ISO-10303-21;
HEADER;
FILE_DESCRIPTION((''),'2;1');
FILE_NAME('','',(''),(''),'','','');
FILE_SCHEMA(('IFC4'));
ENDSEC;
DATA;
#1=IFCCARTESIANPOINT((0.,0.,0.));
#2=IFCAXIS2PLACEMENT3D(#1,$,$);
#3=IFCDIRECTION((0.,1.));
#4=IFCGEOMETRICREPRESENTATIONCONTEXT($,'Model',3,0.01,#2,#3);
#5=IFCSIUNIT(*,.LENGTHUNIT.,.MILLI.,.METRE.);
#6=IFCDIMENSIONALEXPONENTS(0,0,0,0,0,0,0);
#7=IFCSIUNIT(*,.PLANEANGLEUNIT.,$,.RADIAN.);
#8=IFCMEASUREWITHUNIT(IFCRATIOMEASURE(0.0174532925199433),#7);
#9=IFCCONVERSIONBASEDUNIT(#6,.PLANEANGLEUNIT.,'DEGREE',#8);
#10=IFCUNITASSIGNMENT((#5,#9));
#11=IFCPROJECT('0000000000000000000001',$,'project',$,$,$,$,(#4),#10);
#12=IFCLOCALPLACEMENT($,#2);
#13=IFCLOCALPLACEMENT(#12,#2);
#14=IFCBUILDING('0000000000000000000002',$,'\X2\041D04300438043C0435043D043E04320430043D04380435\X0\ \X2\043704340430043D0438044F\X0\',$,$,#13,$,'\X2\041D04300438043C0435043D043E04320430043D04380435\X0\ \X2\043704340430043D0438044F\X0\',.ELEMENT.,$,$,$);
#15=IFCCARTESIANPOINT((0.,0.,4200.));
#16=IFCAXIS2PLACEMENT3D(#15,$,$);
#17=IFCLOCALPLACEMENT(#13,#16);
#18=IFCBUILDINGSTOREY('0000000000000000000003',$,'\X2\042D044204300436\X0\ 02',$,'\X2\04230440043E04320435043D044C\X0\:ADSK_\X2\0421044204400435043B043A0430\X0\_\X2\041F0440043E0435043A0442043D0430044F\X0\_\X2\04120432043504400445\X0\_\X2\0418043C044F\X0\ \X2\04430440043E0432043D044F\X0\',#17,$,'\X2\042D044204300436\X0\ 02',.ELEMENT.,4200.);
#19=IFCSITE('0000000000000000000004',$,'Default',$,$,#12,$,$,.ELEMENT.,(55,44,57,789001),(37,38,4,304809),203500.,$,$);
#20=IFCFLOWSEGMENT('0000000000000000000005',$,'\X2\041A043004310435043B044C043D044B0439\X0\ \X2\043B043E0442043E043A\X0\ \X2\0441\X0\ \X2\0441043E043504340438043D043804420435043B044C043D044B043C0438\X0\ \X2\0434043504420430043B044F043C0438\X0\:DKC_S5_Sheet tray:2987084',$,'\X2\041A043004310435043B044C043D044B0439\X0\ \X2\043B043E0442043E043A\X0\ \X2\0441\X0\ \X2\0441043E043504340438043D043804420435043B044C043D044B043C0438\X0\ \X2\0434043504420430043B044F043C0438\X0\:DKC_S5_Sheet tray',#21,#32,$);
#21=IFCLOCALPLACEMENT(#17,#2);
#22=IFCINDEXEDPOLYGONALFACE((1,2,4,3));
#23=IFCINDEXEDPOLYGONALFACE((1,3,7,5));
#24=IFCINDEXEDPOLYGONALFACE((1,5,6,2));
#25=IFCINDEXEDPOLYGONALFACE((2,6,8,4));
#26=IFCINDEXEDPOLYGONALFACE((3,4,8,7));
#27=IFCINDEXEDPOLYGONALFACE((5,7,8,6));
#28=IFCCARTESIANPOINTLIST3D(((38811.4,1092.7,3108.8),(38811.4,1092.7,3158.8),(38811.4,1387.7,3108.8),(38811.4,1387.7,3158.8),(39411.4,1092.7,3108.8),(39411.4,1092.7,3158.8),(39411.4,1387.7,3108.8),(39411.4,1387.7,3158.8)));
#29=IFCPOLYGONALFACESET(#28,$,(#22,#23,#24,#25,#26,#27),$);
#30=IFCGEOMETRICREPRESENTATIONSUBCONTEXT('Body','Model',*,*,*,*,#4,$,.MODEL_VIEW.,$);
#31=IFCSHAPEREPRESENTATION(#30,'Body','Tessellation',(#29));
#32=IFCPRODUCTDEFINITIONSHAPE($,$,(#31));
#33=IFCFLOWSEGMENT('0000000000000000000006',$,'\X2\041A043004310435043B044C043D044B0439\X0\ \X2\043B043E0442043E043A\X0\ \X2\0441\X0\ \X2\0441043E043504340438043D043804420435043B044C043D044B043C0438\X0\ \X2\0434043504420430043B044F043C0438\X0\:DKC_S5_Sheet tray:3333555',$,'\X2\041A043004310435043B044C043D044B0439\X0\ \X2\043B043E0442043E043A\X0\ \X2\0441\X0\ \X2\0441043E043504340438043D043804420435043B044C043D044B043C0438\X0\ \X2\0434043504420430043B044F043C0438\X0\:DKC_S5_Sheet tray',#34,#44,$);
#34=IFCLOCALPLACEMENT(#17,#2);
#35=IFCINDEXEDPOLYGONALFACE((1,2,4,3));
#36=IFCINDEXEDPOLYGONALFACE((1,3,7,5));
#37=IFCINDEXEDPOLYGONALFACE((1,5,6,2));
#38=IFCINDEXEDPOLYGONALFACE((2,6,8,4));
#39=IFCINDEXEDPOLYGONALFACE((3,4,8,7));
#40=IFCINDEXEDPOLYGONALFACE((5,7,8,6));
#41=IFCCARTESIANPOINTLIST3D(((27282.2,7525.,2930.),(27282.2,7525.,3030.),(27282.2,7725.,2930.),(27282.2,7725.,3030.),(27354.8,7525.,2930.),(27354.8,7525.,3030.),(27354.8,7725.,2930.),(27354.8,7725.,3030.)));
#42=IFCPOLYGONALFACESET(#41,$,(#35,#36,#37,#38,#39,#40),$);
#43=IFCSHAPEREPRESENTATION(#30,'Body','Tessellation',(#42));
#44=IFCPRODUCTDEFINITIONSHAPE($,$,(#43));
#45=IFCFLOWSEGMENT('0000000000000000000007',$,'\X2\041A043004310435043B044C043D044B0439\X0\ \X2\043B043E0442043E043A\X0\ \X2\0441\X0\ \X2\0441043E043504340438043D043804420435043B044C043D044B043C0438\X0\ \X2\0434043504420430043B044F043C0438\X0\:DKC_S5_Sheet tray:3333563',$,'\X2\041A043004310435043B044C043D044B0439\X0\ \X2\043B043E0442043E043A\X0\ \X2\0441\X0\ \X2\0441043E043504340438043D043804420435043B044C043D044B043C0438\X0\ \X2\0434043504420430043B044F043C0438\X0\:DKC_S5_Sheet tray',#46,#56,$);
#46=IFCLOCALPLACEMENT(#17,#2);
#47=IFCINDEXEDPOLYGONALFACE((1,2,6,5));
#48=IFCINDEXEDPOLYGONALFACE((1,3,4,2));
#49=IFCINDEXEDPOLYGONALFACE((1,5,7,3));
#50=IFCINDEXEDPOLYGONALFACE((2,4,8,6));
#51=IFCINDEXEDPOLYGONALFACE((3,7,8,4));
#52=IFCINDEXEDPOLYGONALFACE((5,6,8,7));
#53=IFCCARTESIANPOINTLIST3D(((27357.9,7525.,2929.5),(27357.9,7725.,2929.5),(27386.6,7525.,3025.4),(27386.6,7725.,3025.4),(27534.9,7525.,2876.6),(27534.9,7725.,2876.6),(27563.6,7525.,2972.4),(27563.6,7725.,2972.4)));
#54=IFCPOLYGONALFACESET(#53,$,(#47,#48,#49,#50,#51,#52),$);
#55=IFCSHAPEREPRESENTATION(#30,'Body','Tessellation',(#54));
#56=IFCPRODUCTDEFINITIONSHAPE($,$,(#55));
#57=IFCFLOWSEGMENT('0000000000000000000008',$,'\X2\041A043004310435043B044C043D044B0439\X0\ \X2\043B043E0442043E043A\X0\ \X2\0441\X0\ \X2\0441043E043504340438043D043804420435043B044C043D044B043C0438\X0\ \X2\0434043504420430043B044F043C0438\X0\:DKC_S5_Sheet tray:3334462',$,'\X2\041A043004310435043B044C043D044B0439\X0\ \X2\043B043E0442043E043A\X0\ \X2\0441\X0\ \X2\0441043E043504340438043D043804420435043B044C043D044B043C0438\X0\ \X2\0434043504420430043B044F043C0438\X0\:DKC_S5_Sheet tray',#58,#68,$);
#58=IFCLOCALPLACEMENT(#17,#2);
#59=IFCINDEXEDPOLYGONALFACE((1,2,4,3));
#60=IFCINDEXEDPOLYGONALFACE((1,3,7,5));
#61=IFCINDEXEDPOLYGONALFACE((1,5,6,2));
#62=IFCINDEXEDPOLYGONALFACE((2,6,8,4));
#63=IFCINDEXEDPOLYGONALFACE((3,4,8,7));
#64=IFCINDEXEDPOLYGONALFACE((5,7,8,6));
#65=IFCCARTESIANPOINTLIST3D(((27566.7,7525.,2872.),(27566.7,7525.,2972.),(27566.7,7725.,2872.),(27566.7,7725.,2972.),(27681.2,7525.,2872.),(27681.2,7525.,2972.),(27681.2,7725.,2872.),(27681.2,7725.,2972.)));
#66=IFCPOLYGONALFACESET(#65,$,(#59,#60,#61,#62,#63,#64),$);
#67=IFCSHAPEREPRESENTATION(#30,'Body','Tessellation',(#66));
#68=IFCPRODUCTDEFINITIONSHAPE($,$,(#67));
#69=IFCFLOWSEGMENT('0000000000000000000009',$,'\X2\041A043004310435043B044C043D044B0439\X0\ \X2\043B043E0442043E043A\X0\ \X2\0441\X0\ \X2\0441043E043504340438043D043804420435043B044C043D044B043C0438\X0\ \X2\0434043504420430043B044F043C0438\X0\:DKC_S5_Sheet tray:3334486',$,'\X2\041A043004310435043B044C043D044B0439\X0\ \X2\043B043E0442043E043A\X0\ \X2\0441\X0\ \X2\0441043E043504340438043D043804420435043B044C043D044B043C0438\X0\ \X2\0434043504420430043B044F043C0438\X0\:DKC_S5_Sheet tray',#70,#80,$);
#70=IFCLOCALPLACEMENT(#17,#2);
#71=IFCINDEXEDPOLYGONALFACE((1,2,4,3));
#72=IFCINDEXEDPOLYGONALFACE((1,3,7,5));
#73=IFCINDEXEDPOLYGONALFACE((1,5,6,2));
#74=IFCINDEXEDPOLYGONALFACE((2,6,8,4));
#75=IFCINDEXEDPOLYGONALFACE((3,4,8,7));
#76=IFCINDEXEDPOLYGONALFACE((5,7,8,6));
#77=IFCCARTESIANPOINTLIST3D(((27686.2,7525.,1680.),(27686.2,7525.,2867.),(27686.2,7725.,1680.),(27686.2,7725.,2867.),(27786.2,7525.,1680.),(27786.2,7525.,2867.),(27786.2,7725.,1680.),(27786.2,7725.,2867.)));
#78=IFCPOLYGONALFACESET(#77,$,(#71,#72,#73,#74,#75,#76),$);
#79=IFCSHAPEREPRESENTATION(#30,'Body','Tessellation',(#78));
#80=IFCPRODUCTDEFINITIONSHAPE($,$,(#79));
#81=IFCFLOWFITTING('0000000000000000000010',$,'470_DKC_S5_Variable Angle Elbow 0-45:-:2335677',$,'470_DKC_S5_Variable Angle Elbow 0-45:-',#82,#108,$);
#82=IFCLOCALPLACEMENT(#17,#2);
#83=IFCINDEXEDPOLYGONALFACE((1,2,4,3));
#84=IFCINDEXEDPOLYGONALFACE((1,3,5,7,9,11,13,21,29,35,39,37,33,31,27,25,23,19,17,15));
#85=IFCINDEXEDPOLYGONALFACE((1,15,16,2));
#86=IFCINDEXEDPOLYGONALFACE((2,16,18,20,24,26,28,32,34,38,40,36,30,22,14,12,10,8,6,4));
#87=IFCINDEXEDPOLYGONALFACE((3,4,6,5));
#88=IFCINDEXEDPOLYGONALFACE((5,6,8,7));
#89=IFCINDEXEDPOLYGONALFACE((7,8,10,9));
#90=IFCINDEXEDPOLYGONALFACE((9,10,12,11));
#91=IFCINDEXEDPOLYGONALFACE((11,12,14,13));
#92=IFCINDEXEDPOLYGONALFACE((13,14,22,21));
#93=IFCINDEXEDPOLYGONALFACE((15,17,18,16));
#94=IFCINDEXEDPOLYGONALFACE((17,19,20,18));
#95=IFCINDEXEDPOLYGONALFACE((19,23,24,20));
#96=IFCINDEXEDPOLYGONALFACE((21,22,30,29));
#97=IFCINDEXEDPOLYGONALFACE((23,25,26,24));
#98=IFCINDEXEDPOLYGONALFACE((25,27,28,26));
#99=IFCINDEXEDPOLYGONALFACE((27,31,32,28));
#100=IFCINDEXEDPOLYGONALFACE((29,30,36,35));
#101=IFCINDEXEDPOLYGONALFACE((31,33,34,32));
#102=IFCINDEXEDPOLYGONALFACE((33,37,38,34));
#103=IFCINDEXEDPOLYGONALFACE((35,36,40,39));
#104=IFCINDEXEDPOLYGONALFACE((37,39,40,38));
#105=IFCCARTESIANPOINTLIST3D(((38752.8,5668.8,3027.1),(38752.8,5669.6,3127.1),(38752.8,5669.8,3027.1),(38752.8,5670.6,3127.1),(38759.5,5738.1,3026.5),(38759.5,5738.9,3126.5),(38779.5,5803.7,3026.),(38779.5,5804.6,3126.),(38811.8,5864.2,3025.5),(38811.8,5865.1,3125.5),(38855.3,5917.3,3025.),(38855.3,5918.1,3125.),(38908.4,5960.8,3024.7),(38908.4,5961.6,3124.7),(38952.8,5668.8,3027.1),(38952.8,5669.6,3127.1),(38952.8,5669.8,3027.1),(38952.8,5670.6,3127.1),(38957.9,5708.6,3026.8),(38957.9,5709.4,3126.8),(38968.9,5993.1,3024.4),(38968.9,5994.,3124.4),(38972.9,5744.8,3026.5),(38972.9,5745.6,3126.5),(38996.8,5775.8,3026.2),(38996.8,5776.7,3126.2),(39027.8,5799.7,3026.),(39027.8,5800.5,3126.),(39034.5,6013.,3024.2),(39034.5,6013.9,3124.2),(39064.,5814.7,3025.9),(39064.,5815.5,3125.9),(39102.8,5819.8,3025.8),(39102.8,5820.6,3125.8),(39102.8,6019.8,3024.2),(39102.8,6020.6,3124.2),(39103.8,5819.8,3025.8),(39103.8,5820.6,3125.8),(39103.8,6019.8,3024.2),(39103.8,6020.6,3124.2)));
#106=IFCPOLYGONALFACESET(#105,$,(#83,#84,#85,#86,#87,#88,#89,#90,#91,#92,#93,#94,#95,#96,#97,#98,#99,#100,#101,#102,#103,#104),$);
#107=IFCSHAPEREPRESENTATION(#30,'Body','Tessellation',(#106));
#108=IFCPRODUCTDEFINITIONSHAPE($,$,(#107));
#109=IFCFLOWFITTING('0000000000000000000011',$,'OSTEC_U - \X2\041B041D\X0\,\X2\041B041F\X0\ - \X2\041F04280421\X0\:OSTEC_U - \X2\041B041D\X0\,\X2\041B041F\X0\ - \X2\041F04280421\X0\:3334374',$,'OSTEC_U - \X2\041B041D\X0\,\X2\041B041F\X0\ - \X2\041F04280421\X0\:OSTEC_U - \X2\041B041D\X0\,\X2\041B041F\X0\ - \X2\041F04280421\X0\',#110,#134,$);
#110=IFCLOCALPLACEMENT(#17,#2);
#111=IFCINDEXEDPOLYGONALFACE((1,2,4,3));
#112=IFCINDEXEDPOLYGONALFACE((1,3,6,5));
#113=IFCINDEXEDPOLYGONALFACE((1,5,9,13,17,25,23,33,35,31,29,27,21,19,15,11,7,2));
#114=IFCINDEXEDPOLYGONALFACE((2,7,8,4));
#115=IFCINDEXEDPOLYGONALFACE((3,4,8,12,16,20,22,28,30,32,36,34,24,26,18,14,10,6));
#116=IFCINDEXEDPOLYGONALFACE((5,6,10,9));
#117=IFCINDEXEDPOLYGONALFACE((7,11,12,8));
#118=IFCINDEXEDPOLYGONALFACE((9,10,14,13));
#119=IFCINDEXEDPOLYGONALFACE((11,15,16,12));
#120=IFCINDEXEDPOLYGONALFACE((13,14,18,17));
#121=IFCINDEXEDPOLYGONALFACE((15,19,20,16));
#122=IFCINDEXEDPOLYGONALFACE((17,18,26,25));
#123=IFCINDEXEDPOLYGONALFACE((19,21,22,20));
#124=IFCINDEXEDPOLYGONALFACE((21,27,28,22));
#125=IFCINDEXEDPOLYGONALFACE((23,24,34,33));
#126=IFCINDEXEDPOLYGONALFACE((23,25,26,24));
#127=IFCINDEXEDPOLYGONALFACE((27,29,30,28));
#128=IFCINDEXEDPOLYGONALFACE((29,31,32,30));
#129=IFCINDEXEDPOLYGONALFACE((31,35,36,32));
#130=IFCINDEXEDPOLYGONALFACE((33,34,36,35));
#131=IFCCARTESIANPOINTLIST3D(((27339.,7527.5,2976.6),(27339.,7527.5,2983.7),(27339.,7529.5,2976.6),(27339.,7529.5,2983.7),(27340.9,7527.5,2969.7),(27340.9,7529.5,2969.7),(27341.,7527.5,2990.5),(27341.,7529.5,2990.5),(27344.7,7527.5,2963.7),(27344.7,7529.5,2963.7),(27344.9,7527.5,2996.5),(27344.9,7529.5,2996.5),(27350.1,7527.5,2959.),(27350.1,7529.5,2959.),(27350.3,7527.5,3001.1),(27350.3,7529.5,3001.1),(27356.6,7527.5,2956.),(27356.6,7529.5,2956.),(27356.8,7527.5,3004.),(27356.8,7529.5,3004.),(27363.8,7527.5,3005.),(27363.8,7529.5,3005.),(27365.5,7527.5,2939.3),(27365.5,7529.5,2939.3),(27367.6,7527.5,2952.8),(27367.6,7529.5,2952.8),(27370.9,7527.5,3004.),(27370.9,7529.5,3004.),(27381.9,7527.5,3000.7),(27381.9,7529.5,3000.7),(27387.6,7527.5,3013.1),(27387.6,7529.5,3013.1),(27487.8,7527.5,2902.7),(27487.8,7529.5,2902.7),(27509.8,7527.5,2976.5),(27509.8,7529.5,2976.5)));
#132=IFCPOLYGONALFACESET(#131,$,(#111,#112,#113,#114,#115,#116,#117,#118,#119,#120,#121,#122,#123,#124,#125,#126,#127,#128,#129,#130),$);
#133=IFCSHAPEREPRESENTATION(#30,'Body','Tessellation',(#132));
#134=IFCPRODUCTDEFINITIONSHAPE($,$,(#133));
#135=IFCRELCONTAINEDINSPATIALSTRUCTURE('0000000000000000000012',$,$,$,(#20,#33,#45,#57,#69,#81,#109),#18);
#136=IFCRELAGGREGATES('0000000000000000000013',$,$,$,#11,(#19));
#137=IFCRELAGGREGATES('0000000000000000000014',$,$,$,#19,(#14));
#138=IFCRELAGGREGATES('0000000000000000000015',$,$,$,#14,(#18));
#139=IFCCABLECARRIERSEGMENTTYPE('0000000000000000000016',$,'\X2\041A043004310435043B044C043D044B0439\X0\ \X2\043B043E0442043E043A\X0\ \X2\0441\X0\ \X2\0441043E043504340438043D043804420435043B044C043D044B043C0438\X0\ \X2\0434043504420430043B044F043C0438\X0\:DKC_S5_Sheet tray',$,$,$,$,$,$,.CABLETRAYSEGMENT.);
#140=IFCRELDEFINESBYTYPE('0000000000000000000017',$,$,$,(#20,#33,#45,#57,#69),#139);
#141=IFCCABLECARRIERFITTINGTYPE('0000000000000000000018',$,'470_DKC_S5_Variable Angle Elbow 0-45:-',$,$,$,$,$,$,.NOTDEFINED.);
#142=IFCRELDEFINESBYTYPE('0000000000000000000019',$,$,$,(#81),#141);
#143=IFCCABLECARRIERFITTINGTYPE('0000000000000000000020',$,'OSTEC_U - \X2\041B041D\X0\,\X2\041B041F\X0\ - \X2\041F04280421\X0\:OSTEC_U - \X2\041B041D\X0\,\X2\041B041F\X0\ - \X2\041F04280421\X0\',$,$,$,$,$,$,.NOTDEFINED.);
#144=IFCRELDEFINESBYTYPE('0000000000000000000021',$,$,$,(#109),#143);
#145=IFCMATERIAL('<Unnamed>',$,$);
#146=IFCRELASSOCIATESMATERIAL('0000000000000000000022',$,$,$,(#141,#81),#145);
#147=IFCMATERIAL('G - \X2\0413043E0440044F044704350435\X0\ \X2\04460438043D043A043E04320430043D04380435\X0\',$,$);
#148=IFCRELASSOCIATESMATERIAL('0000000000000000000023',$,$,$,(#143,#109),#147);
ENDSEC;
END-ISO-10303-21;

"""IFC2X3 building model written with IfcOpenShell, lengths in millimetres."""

from ifc_helpers import new_model, entity, si_unit, converted_unit, direction, frame, frame_2d, origin, origin_2d_with_axis, place, context, subcontext, project, spatial, polyline, circle_curve, parameter, trimmed, segment, composite_curve, rectangle, outline, extrude, source, transform, mapped, material, type_object, type_shapes, element, save


model = new_model("IFC2X3")

# Units and contexts
model_context = context("Model", 3, precision=0.01, world=origin(), true_north=direction((0.0, 1.0)))
body_context = subcontext(model_context, "Body", "Model", "MODEL_VIEW")
ifc_project = project(units=[si_unit("LENGTHUNIT", "METRE", prefix="MILLI"), converted_unit("PLANEANGLEUNIT", "DEGREE", entity("IfcRatioMeasure", 0.0174532925199433), si_unit("PLANEANGLEUNIT", "RADIAN"), dimensions=[0, 0, 0, 0, 0, 0, 0])], contexts=[model_context])

# Site, building, storey
site_placement = place(None, origin())
site = spatial("IfcSite", under=ifc_project, at=site_placement, Name="Default", CompositionType="ELEMENT", RefLatitude=(55, 44, 57, 789001), RefLongitude=(37, 38, 4, 304809), RefElevation=203500.0)
building_placement = place(site_placement, origin())
building = spatial("IfcBuilding", under=site, at=building_placement, Name="Наименование здания", LongName="Наименование здания", CompositionType="ELEMENT")
storey_placement = place(building_placement, frame((0.0, 0.0, 4200.0)))
storey = spatial("IfcBuildingStorey", under=building, at=storey_placement, Name="Этаж 02", ObjectType="Уровень:ADSK_Стрелка_Проектная_Вверх_Имя уровня", LongName="Этаж 02", CompositionType="ELEMENT", Elevation=4200.0)

# Flow segments
cable_carrier_segment_type = type_object("IfcCableCarrierSegmentType", Name="Кабельный лоток с соединительными деталями:DKC_S5_Sheet tray", PredefinedType="CABLETRAYSEGMENT")
flow_segment_1_placement = place(storey_placement, frame((38811.4, 1092.7, 3108.8)))
element("IfcFlowSegment", 1, at=flow_segment_1_placement, inside=storey, type_object=cable_carrier_segment_type, Name="Кабельный лоток с соединительными деталями:DKC_S5_Sheet tray:2987084", ObjectType="Кабельный лоток с соединительными деталями:DKC_S5_Sheet tray", context=body_context, shape_type="SweptSolid", body=[
    extrude(rectangle(XDim=295.1, YDim=600.0, at=origin_2d_with_axis()), frame((300.0, 147.5, 0.0), z_axis=(0.0, 0.0, 1.0), x_axis=(0.0, 1.0, 0.0)), (0.0, 0.0, 1.0), 50.0),
])
flow_segment_2_placement = place(storey_placement, frame((27282.2, 7525.0, 2930.0)))
element("IfcFlowSegment", 2, at=flow_segment_2_placement, inside=storey, type_object=cable_carrier_segment_type, Name="Кабельный лоток с соединительными деталями:DKC_S5_Sheet tray:3333555", ObjectType="Кабельный лоток с соединительными деталями:DKC_S5_Sheet tray", context=body_context, shape_type="SweptSolid", body=[
    extrude(rectangle(XDim=72.6, YDim=200.0, at=origin_2d_with_axis()), frame((36.3, 100.0, 0.0)), (0.0, 0.0, 1.0), 100.0),
])
flow_segment_3_placement = place(storey_placement, frame((27357.9, 7525.0, 2876.6)))
element("IfcFlowSegment", 3, at=flow_segment_3_placement, inside=storey, type_object=cable_carrier_segment_type, Name="Кабельный лоток с соединительными деталями:DKC_S5_Sheet tray:3333563", ObjectType="Кабельный лоток с соединительными деталями:DKC_S5_Sheet tray", context=body_context, shape_type="SweptSolid", body=[
    extrude(rectangle(XDim=100.0, YDim=184.8, at=frame_2d((0.0, 0.0), x_axis=(0.0, 1.0))), frame((102.8, 0.0, 74.4), z_axis=(0.0, 1.0, 0.0), x_axis=(0.958072, 0.0, -0.286526)), (0.0, 0.0, 1.0), 200.0),
])
flow_segment_4_placement = place(storey_placement, frame((27566.7, 7525.0, 2872.0)))
element("IfcFlowSegment", 4, at=flow_segment_4_placement, inside=storey, type_object=cable_carrier_segment_type, Name="Кабельный лоток с соединительными деталями:DKC_S5_Sheet tray:3334462", ObjectType="Кабельный лоток с соединительными деталями:DKC_S5_Sheet tray", context=body_context, shape_type="SweptSolid", body=[
    extrude(rectangle(XDim=114.5, YDim=200.0, at=origin_2d_with_axis()), frame((57.3, 100.0, 0.0)), (0.0, 0.0, 1.0), 100.0),
])
flow_segment_5_placement = place(storey_placement, frame((27686.2, 7525.0, 1680.0)))
element("IfcFlowSegment", 5, at=flow_segment_5_placement, inside=storey, type_object=cable_carrier_segment_type, Name="Кабельный лоток с соединительными деталями:DKC_S5_Sheet tray:3334486", ObjectType="Кабельный лоток с соединительными деталями:DKC_S5_Sheet tray", context=body_context, shape_type="SweptSolid", body=[
    extrude(rectangle(XDim=100.0, YDim=200.0, at=origin_2d_with_axis()), frame((50.0, 100.0, 0.0)), (0.0, 0.0, 1.0), 1187.0),
])

# Flow fittings
ifc_material_1 = material(Name="<Unnamed>")
cable_carrier_fitting_type_1 = type_object("IfcCableCarrierFittingType", Name="470_DKC_S5_Variable Angle Elbow 0-45:-", PredefinedType="NOTDEFINED", material=ifc_material_1)
shared_shape_1 = source(origin(), body_context, "Body", "SweptSolid", [
    extrude(outline(composite_curve([segment(polyline([(-125.8, -225.2), (-124.8, -225.2)]), True, "CONTINUOUS"), segment(trimmed(circle_curve(frame_2d((-124.8, 124.8), x_axis=(0.0, -1.0)), 350.0), [parameter(0.0)], [parameter(90.0)], True, "PARAMETER"), True, "CONTINUOUS"), segment(polyline([(225.2, 124.8), (225.2, 125.8)]), True, "CONTINUOUS"), segment(polyline([(225.2, 125.8), (25.2, 125.8)]), True, "CONTINUOUS"), segment(polyline([(25.2, 125.8), (25.2, 124.8)]), True, "CONTINUOUS"), segment(trimmed(circle_curve(frame_2d((-124.8, 124.8), x_axis=(0.0, -1.0)), 150.0), [parameter(0.0)], [parameter(90.0)], True, "PARAMETER"), False, "CONTINUOUS"), segment(polyline([(-124.8, -25.2), (-125.8, -25.2)]), True, "CONTINUOUS"), segment(polyline([(-125.8, -25.2), (-125.8, -225.2)]), True, "CONTINUOUS")], self_intersect=False)), frame((-125.2, 125.2, -50.0)), (0.0, 0.0, 1.0), 100.0),
])
type_shapes(cable_carrier_fitting_type_1, [shared_shape_1])
flow_fitting_1_placement = place(storey_placement, frame((38852.8, 5920.2, 3075.0), z_axis=(0.0, 0.00846, 0.999964), x_axis=(-1.0, 0.0, 0.0)))
element("IfcFlowFitting", 6, at=flow_fitting_1_placement, inside=storey, type_object=cable_carrier_fitting_type_1, material=ifc_material_1, Name="470_DKC_S5_Variable Angle Elbow 0-45:-:2335677", ObjectType="470_DKC_S5_Variable Angle Elbow 0-45:-", context=body_context, shape_type="MappedRepresentation", body=[
    mapped(shared_shape_1, transform((0.0, 0.0, 0.0), scale=1.0)),
])
ifc_material_2 = material(Name="G - Горячее цинкование")
cable_carrier_fitting_type_2 = type_object("IfcCableCarrierFittingType", Name="OSTEC_U - ЛН,ЛП - ПШС:OSTEC_U - ЛН,ЛП - ПШС", PredefinedType="NOTDEFINED", material=ifc_material_2)
shared_shape_2 = source(origin(), body_context, "Body", "SweptSolid", [
    extrude(outline(composite_curve([segment(trimmed(circle_curve(frame_2d((-41.5, 0.0), x_axis=(1.0, 0.0)), 25.0), [parameter(90.0)], [parameter(270.0)], True, "PARAMETER"), True, "CONTINUOUS"), segment(polyline([(-41.5, -25.0), (-30.0, -25.0)]), True, "CONTINUOUS"), segment(polyline([(-30.0, -25.0), (-28.1, -38.5)]), True, "CONTINUOUS"), segment(polyline([(-28.1, -38.5), (99.5, -38.5)]), True, "CONTINUOUS"), segment(polyline([(99.5, -38.5), (99.5, 38.5)]), True, "CONTINUOUS"), segment(polyline([(99.5, 38.5), (-28.1, 38.5)]), True, "CONTINUOUS"), segment(polyline([(-28.1, 38.5), (-30.0, 25.0)]), True, "CONTINUOUS"), segment(polyline([(-30.0, 25.0), (-41.5, 25.0)]), True, "CONTINUOUS")], self_intersect=False)), frame((41.5, 0.0, 0.0)), (0.0, 0.0, 1.0), 2.0),
])
type_shapes(cable_carrier_fitting_type_2, [shared_shape_2])
flow_fitting_2_placement = place(storey_placement, frame((27363.7, 7529.5, 2980.0), z_axis=(0.0, -1.0, 0.0), x_axis=(0.958072, 0.0, -0.286526)))
element("IfcFlowFitting", 7, at=flow_fitting_2_placement, inside=storey, type_object=cable_carrier_fitting_type_2, material=ifc_material_2, Name="OSTEC_U - ЛН,ЛП - ПШС:OSTEC_U - ЛН,ЛП - ПШС:3334374", ObjectType="OSTEC_U - ЛН,ЛП - ПШС:OSTEC_U - ЛН,ЛП - ПШС", context=body_context, shape_type="MappedRepresentation", body=[
    mapped(shared_shape_2, transform((0.0, 0.0, 0.0), scale=1.0)),
])

save(model, "model.ifc")
